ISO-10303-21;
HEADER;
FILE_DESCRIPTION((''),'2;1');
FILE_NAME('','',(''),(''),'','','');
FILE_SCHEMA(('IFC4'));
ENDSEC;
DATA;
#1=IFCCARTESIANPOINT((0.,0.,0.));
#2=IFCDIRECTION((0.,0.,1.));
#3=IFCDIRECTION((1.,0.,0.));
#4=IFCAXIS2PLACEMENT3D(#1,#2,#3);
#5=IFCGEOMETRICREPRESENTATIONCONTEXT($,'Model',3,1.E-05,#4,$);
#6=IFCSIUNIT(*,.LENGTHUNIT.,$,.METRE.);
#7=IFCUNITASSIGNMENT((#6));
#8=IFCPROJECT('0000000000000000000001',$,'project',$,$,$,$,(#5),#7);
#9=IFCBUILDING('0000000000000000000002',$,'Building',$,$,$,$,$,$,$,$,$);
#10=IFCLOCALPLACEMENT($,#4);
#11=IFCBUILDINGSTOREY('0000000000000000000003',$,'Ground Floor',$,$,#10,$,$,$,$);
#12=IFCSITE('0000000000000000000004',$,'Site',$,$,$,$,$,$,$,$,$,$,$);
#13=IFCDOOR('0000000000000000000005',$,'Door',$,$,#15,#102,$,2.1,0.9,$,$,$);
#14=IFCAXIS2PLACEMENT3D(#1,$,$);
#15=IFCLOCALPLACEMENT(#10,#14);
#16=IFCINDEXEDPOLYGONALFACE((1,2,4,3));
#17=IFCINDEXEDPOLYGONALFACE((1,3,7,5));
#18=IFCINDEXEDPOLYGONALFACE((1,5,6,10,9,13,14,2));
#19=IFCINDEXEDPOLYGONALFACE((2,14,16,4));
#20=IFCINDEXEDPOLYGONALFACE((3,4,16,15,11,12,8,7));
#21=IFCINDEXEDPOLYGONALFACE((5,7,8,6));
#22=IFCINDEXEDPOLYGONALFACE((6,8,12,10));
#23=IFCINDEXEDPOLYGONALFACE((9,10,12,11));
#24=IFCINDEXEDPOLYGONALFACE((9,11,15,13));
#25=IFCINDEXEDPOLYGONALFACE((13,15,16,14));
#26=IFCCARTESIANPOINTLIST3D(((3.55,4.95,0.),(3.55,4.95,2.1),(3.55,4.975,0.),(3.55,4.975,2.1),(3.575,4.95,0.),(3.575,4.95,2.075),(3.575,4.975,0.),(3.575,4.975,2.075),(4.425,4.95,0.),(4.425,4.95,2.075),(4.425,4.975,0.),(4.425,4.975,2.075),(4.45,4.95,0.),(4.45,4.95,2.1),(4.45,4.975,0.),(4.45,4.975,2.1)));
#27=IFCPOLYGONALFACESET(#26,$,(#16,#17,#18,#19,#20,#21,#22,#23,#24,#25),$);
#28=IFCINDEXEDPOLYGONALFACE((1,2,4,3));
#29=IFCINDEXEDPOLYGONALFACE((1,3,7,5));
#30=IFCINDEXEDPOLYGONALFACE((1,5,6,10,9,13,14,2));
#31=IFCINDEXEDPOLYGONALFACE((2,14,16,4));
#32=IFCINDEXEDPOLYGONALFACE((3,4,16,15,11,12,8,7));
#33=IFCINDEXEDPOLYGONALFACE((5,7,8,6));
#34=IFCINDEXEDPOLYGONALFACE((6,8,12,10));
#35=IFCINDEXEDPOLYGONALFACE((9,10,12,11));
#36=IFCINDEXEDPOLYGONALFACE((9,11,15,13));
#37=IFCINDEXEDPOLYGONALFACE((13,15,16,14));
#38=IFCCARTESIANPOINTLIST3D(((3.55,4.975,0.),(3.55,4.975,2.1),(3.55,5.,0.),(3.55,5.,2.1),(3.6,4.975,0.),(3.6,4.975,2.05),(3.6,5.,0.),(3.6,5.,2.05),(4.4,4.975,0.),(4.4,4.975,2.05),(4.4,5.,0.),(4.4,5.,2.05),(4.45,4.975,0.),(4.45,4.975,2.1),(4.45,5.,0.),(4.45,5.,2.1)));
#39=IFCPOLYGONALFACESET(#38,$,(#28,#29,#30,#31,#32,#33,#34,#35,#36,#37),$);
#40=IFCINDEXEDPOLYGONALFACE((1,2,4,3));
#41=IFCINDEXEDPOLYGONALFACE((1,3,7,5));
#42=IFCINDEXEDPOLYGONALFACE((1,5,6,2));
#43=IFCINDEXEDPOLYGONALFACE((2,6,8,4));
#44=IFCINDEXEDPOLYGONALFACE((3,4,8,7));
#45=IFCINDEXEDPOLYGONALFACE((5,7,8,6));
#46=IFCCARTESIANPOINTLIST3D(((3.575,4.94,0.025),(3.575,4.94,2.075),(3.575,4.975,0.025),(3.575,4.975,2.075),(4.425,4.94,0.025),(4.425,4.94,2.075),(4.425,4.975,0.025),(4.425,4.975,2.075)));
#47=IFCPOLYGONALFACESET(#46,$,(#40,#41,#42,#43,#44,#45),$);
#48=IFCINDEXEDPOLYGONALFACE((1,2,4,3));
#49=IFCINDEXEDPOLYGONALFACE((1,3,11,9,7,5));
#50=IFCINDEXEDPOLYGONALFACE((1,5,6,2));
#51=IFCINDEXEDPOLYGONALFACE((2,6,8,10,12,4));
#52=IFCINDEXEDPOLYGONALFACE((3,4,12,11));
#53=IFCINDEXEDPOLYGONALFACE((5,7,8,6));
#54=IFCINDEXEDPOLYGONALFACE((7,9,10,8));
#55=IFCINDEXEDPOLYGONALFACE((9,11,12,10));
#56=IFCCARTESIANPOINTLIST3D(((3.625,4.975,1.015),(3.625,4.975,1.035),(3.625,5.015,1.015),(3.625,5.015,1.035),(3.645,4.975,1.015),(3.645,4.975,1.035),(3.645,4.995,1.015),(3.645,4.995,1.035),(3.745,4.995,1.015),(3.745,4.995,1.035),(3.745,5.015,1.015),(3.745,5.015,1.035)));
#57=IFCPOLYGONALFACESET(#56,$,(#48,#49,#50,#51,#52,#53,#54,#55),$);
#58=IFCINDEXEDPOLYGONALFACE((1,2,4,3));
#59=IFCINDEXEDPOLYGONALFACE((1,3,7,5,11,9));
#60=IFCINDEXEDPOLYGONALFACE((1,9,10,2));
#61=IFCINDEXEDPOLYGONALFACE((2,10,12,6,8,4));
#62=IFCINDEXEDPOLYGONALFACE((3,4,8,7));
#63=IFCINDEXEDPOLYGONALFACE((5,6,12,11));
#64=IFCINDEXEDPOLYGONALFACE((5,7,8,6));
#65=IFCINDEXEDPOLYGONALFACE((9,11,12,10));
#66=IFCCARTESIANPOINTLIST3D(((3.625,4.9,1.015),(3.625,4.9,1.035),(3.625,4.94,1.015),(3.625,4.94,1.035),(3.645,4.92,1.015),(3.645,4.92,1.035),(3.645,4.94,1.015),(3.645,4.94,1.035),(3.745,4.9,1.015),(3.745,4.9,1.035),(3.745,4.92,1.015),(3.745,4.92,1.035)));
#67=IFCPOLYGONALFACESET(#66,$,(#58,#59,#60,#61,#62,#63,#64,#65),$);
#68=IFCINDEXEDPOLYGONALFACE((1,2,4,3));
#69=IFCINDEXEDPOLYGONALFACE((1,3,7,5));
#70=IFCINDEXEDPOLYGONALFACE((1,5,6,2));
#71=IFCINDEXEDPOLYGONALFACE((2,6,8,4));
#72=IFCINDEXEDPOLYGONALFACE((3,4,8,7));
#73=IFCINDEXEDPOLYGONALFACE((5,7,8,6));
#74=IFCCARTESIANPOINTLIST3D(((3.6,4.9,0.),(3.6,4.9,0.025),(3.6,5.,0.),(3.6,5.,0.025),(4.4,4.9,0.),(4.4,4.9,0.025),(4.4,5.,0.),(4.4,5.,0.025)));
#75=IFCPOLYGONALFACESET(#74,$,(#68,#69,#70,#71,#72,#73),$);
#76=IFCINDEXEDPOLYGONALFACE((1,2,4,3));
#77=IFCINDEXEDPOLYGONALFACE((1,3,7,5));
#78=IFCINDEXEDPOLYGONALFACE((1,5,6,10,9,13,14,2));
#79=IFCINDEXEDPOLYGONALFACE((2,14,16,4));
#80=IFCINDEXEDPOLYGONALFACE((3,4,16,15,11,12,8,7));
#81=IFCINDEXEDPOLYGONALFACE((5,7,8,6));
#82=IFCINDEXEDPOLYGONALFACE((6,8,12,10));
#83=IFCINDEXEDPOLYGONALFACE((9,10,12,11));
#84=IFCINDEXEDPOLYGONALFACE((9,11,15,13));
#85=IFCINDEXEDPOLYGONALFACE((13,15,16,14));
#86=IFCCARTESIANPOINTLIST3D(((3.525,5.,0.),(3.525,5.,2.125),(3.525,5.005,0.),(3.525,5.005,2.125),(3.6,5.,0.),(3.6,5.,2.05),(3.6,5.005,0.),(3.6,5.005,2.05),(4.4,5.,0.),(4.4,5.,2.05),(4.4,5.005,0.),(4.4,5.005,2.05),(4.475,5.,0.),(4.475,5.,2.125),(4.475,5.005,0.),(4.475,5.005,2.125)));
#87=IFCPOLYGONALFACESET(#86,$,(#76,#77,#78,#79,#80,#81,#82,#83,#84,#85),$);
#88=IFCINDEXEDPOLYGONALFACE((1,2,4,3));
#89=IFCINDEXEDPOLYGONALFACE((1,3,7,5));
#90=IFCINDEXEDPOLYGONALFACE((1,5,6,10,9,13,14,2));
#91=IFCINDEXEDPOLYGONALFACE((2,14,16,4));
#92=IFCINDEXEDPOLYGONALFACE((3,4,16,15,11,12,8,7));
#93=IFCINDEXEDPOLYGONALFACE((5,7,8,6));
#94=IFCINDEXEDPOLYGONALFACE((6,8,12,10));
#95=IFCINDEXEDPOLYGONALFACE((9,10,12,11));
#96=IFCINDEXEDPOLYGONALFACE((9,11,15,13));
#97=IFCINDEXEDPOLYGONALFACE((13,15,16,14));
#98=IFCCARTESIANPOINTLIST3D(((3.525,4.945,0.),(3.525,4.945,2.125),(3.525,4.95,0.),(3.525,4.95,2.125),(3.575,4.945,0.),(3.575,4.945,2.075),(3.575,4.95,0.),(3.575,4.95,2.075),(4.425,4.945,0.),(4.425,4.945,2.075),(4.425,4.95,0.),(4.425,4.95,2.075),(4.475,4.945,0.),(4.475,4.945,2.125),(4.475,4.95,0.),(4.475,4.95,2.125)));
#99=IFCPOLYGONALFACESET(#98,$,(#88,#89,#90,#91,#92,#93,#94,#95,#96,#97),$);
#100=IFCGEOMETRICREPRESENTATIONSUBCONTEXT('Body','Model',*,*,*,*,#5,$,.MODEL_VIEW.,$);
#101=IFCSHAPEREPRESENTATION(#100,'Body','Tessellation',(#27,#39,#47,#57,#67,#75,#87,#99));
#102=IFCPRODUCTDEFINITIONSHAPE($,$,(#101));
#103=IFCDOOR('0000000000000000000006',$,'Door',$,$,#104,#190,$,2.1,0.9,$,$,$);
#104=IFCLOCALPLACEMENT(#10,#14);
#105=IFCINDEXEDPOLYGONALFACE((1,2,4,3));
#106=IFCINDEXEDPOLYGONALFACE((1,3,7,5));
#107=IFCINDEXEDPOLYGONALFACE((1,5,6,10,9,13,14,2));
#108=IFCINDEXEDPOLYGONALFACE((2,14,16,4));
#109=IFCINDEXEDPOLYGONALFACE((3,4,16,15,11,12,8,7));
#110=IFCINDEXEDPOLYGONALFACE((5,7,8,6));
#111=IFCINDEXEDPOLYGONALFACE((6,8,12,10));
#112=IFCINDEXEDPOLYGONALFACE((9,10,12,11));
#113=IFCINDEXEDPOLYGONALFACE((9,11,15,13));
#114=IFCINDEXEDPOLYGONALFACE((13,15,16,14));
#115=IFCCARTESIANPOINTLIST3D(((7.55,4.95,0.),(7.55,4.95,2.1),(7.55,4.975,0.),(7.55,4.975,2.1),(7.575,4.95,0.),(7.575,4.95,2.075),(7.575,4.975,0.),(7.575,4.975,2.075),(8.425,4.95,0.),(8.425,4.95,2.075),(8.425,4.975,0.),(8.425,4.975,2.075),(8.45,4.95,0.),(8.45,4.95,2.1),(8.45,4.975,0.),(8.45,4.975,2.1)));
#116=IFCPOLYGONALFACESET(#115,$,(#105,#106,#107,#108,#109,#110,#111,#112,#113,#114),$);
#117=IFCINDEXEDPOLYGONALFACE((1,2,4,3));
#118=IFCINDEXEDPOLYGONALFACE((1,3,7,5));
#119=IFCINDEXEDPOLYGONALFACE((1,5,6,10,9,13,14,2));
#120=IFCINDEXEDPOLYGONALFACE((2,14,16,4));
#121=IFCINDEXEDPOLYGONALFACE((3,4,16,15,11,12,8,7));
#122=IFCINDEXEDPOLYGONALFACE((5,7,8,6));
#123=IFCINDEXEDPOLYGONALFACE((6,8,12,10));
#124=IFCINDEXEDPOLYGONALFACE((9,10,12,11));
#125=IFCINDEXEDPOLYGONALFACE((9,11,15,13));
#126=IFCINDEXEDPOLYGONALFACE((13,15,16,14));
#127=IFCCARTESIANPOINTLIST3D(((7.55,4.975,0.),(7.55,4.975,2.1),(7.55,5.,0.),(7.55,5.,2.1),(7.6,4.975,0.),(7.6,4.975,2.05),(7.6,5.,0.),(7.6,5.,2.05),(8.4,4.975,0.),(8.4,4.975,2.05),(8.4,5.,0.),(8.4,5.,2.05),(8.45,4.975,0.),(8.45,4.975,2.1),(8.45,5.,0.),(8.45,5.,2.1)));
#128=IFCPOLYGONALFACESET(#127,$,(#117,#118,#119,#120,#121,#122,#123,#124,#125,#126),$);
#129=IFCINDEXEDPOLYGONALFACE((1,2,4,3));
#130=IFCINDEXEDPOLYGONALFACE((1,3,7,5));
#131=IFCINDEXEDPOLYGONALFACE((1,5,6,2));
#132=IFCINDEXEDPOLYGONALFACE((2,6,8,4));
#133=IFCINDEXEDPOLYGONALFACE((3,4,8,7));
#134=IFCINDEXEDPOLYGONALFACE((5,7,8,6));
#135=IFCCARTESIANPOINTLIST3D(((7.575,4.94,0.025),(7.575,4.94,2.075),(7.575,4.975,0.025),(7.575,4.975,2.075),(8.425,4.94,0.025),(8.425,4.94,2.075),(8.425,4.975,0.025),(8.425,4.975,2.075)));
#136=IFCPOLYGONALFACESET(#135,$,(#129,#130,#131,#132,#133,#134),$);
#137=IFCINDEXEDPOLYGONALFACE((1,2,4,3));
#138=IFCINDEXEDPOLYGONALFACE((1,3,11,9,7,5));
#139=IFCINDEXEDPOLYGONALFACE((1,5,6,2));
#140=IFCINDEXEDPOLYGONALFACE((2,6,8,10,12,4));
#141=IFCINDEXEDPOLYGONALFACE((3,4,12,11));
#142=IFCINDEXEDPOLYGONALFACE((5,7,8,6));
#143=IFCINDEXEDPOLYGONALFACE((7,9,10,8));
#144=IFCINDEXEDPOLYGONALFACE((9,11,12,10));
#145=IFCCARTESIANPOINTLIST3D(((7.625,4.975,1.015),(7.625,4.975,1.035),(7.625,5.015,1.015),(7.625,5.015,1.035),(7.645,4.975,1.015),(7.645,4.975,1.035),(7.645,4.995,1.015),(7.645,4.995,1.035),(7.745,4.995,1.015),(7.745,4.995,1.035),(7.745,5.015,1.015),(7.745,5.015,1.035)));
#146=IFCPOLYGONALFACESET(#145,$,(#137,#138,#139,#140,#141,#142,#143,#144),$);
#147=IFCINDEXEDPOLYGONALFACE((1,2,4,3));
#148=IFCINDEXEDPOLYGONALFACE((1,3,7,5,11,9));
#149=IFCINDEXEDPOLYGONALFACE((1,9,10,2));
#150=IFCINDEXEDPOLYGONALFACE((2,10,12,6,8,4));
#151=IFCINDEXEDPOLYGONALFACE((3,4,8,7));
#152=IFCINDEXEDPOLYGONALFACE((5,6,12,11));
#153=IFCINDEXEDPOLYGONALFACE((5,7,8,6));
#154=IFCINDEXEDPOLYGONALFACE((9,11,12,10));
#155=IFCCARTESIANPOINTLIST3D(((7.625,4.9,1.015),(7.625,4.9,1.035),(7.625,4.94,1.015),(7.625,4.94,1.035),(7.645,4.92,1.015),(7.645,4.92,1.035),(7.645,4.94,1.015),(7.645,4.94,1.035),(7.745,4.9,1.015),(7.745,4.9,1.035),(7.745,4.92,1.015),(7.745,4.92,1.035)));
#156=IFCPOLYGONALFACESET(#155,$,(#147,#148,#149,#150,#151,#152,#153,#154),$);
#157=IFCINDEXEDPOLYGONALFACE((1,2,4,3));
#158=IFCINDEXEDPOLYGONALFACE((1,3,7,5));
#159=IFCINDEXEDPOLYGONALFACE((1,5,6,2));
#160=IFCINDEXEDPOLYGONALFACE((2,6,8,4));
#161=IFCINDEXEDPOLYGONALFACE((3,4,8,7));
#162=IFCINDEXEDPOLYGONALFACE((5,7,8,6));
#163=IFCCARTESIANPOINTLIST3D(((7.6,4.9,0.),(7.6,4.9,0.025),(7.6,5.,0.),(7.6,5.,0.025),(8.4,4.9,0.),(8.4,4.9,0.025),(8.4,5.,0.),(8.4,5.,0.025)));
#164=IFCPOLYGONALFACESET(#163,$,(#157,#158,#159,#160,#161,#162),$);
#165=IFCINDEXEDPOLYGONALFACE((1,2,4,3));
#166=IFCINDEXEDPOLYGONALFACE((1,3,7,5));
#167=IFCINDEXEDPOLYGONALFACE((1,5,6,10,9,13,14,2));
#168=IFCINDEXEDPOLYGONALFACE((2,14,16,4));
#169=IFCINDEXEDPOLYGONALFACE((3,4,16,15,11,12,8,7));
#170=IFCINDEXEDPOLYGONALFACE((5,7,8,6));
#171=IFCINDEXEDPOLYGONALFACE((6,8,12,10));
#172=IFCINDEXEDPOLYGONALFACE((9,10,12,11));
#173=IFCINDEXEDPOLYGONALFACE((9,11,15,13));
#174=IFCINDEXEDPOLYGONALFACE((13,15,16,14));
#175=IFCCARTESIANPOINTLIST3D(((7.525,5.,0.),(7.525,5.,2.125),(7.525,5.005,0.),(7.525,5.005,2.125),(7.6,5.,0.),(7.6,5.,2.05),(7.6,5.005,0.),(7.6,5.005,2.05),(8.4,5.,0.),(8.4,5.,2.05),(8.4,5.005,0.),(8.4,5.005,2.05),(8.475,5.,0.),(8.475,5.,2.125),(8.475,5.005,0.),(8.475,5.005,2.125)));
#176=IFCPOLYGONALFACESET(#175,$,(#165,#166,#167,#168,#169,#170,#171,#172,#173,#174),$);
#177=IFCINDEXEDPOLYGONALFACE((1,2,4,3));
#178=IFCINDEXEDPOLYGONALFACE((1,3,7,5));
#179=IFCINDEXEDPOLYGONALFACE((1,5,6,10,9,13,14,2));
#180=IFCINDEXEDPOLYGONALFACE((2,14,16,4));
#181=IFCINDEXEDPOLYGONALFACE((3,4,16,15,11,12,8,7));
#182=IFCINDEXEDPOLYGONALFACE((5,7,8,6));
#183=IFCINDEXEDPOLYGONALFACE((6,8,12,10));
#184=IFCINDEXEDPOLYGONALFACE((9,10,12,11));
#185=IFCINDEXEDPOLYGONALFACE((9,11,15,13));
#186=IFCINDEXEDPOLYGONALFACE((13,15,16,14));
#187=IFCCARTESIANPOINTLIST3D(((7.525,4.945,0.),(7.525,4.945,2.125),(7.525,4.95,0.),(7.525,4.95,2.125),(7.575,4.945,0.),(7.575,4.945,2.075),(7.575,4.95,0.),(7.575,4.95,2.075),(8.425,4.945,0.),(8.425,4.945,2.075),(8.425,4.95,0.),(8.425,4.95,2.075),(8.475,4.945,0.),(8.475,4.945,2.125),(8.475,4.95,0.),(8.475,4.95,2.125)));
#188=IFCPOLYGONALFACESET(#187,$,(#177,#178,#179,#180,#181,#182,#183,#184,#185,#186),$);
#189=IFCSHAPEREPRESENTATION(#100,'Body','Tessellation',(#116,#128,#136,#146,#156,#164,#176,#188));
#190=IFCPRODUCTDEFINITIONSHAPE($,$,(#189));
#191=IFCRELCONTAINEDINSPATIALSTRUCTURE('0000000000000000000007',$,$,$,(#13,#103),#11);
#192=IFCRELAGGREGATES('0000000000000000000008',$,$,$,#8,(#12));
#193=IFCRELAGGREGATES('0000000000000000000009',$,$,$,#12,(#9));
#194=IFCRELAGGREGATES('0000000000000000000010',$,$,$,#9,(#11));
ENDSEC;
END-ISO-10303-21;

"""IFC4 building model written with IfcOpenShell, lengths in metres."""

from ifc_helpers import new_model, si_unit, frame, origin_with_axes, place, context, subcontext, project, spatial, line, indexed_curve, outline, extrude, element, save


model = new_model("IFC4")

# Units and contexts
model_context = context("Model", 3, precision=1e-05, world=origin_with_axes())
body_context = subcontext(model_context, "Body", "Model", "MODEL_VIEW")
ifc_project = project(units=[si_unit("LENGTHUNIT", "METRE")], contexts=[model_context])

# Site, building, storey
site = spatial("IfcSite", under=ifc_project, Name="Site")
building = spatial("IfcBuilding", under=site, Name="Building")
storey_placement = place(None, origin_with_axes())
storey = spatial("IfcBuildingStorey", under=building, at=storey_placement, Name="Ground Floor")

# Doors
door_1_placement = place(storey_placement, frame((4.45, 5.0, 0.0), z_axis=(0.0, 0.0, 1.0), x_axis=(-1.0, 0.0, 0.0)))
element("IfcDoor", 1, at=door_1_placement, inside=storey, Name="Door", OverallHeight=2.1, OverallWidth=0.9, context=body_context, shape_type="SweptSolid", body=[
    extrude(outline(indexed_curve([(0.0, 0.0), (0.0, 2.1), (0.9, 2.1), (0.9, 0.0), (0.875, 0.0), (0.875, 2.075), (0.025, 2.075), (0.025, 0.0)], segments=[line(1, 2, 3, 4, 5, 6, 7, 8, 1)])), frame((0.0, 0.025, 0.0), z_axis=(0.0, -1.0, 0.0), x_axis=(1.0, 0.0, 0.0)), (0.0, 0.0, -1.0), 0.025),
    extrude(outline(indexed_curve([(0.0, 0.0), (0.0, 2.1), (0.9, 2.1), (0.9, 0.0), (0.85, 0.0), (0.85, 2.05), (0.05, 2.05), (0.05, 0.0)], segments=[line(1, 2, 3, 4, 5, 6, 7, 8, 1)])), frame((0.0, 0.0, 0.0), z_axis=(0.0, -1.0, 0.0), x_axis=(1.0, 0.0, 0.0)), (0.0, 0.0, -1.0), 0.025),
    extrude(outline(indexed_curve([(0.0, 0.0), (0.85, 0.0), (0.85, 0.035), (0.0, 0.035)], segments=[line(1, 2, 3, 4, 1)])), frame((0.025, 0.025, 0.025), z_axis=(0.0, 0.0, 1.0), x_axis=(1.0, 0.0, 0.0)), (0.0, 0.0, 1.0), 2.05),
    extrude(outline(indexed_curve([(0.0, 0.0), (0.0, -0.04), (-0.12, -0.04), (-0.12, -0.02), (-0.02, -0.02), (-0.02, 0.0)], segments=[line(1, 2, 3, 4, 5, 6, 1)])), frame((0.825, 0.025, 1.015), z_axis=(0.0, 0.0, 1.0), x_axis=(1.0, 0.0, 0.0)), (0.0, 0.0, 1.0), 0.02),
    extrude(outline(indexed_curve([(0.0, 0.0), (0.0, 0.04), (-0.12, 0.04), (-0.12, 0.02), (-0.02, 0.02), (-0.02, 0.0)], segments=[line(1, 2, 3, 4, 5, 6, 1)])), frame((0.825, 0.06, 1.015), z_axis=(0.0, 0.0, 1.0), x_axis=(1.0, 0.0, 0.0)), (0.0, 0.0, 1.0), 0.02),
    extrude(outline(indexed_curve([(0.0, 0.0), (0.8, 0.0), (0.8, 0.1), (0.0, 0.1)], segments=[line(1, 2, 3, 4, 1)])), frame((0.05, 0.0, 0.0), z_axis=(0.0, 0.0, 1.0), x_axis=(1.0, 0.0, 0.0)), (0.0, 0.0, 1.0), 0.025),
    extrude(outline(indexed_curve([(0.0, 0.0), (0.0, 2.125), (0.95, 2.125), (0.95, 0.0), (0.875, 0.0), (0.875, 2.05), (0.075, 2.05), (0.075, 0.0)], segments=[line(1, 2, 3, 4, 5, 6, 7, 8, 1)])), frame((-0.025, -0.005, 0.0), z_axis=(0.0, -1.0, 0.0), x_axis=(1.0, 0.0, 0.0)), (0.0, 0.0, -1.0), 0.005),
    extrude(outline(indexed_curve([(0.0, 0.0), (0.0, 2.125), (0.95, 2.125), (0.95, 0.0), (0.9, 0.0), (0.9, 2.075), (0.05, 2.075), (0.05, 0.0)], segments=[line(1, 2, 3, 4, 5, 6, 7, 8, 1)])), frame((-0.025, 0.05, 0.0), z_axis=(0.0, -1.0, 0.0), x_axis=(1.0, 0.0, 0.0)), (0.0, 0.0, -1.0), 0.005),
])
door_2_placement = place(storey_placement, frame((8.45, 5.0, 0.0), z_axis=(0.0, 0.0, 1.0), x_axis=(-1.0, 0.0, 0.0)))
element("IfcDoor", 2, at=door_2_placement, inside=storey, Name="Door", OverallHeight=2.1, OverallWidth=0.9, context=body_context, shape_type="SweptSolid", body=[
    extrude(outline(indexed_curve([(0.0, 0.0), (0.0, 2.1), (0.9, 2.1), (0.9, 0.0), (0.875, 0.0), (0.875, 2.075), (0.025, 2.075), (0.025, 0.0)], segments=[line(1, 2, 3, 4, 5, 6, 7, 8, 1)])), frame((0.0, 0.025, 0.0), z_axis=(0.0, -1.0, 0.0), x_axis=(1.0, 0.0, 0.0)), (0.0, 0.0, -1.0), 0.025),
    extrude(outline(indexed_curve([(0.0, 0.0), (0.0, 2.1), (0.9, 2.1), (0.9, 0.0), (0.85, 0.0), (0.85, 2.05), (0.05, 2.05), (0.05, 0.0)], segments=[line(1, 2, 3, 4, 5, 6, 7, 8, 1)])), frame((0.0, 0.0, 0.0), z_axis=(0.0, -1.0, 0.0), x_axis=(1.0, 0.0, 0.0)), (0.0, 0.0, -1.0), 0.025),
    extrude(outline(indexed_curve([(0.0, 0.0), (0.85, 0.0), (0.85, 0.035), (0.0, 0.035)], segments=[line(1, 2, 3, 4, 1)])), frame((0.025, 0.025, 0.025), z_axis=(0.0, 0.0, 1.0), x_axis=(1.0, 0.0, 0.0)), (0.0, 0.0, 1.0), 2.05),
    extrude(outline(indexed_curve([(0.0, 0.0), (0.0, -0.04), (-0.12, -0.04), (-0.12, -0.02), (-0.02, -0.02), (-0.02, 0.0)], segments=[line(1, 2, 3, 4, 5, 6, 1)])), frame((0.825, 0.025, 1.015), z_axis=(0.0, 0.0, 1.0), x_axis=(1.0, 0.0, 0.0)), (0.0, 0.0, 1.0), 0.02),
    extrude(outline(indexed_curve([(0.0, 0.0), (0.0, 0.04), (-0.12, 0.04), (-0.12, 0.02), (-0.02, 0.02), (-0.02, 0.0)], segments=[line(1, 2, 3, 4, 5, 6, 1)])), frame((0.825, 0.06, 1.015), z_axis=(0.0, 0.0, 1.0), x_axis=(1.0, 0.0, 0.0)), (0.0, 0.0, 1.0), 0.02),
    extrude(outline(indexed_curve([(0.0, 0.0), (0.8, 0.0), (0.8, 0.1), (0.0, 0.1)], segments=[line(1, 2, 3, 4, 1)])), frame((0.05, 0.0, 0.0), z_axis=(0.0, 0.0, 1.0), x_axis=(1.0, 0.0, 0.0)), (0.0, 0.0, 1.0), 0.025),
    extrude(outline(indexed_curve([(0.0, 0.0), (0.0, 2.125), (0.95, 2.125), (0.95, 0.0), (0.875, 0.0), (0.875, 2.05), (0.075, 2.05), (0.075, 0.0)], segments=[line(1, 2, 3, 4, 5, 6, 7, 8, 1)])), frame((-0.025, -0.005, 0.0), z_axis=(0.0, -1.0, 0.0), x_axis=(1.0, 0.0, 0.0)), (0.0, 0.0, -1.0), 0.005),
    extrude(outline(indexed_curve([(0.0, 0.0), (0.0, 2.125), (0.95, 2.125), (0.95, 0.0), (0.9, 0.0), (0.9, 2.075), (0.05, 2.075), (0.05, 0.0)], segments=[line(1, 2, 3, 4, 5, 6, 7, 8, 1)])), frame((-0.025, 0.05, 0.0), z_axis=(0.0, -1.0, 0.0), x_axis=(1.0, 0.0, 0.0)), (0.0, 0.0, -1.0), 0.005),
])

save(model, "model.ifc")
